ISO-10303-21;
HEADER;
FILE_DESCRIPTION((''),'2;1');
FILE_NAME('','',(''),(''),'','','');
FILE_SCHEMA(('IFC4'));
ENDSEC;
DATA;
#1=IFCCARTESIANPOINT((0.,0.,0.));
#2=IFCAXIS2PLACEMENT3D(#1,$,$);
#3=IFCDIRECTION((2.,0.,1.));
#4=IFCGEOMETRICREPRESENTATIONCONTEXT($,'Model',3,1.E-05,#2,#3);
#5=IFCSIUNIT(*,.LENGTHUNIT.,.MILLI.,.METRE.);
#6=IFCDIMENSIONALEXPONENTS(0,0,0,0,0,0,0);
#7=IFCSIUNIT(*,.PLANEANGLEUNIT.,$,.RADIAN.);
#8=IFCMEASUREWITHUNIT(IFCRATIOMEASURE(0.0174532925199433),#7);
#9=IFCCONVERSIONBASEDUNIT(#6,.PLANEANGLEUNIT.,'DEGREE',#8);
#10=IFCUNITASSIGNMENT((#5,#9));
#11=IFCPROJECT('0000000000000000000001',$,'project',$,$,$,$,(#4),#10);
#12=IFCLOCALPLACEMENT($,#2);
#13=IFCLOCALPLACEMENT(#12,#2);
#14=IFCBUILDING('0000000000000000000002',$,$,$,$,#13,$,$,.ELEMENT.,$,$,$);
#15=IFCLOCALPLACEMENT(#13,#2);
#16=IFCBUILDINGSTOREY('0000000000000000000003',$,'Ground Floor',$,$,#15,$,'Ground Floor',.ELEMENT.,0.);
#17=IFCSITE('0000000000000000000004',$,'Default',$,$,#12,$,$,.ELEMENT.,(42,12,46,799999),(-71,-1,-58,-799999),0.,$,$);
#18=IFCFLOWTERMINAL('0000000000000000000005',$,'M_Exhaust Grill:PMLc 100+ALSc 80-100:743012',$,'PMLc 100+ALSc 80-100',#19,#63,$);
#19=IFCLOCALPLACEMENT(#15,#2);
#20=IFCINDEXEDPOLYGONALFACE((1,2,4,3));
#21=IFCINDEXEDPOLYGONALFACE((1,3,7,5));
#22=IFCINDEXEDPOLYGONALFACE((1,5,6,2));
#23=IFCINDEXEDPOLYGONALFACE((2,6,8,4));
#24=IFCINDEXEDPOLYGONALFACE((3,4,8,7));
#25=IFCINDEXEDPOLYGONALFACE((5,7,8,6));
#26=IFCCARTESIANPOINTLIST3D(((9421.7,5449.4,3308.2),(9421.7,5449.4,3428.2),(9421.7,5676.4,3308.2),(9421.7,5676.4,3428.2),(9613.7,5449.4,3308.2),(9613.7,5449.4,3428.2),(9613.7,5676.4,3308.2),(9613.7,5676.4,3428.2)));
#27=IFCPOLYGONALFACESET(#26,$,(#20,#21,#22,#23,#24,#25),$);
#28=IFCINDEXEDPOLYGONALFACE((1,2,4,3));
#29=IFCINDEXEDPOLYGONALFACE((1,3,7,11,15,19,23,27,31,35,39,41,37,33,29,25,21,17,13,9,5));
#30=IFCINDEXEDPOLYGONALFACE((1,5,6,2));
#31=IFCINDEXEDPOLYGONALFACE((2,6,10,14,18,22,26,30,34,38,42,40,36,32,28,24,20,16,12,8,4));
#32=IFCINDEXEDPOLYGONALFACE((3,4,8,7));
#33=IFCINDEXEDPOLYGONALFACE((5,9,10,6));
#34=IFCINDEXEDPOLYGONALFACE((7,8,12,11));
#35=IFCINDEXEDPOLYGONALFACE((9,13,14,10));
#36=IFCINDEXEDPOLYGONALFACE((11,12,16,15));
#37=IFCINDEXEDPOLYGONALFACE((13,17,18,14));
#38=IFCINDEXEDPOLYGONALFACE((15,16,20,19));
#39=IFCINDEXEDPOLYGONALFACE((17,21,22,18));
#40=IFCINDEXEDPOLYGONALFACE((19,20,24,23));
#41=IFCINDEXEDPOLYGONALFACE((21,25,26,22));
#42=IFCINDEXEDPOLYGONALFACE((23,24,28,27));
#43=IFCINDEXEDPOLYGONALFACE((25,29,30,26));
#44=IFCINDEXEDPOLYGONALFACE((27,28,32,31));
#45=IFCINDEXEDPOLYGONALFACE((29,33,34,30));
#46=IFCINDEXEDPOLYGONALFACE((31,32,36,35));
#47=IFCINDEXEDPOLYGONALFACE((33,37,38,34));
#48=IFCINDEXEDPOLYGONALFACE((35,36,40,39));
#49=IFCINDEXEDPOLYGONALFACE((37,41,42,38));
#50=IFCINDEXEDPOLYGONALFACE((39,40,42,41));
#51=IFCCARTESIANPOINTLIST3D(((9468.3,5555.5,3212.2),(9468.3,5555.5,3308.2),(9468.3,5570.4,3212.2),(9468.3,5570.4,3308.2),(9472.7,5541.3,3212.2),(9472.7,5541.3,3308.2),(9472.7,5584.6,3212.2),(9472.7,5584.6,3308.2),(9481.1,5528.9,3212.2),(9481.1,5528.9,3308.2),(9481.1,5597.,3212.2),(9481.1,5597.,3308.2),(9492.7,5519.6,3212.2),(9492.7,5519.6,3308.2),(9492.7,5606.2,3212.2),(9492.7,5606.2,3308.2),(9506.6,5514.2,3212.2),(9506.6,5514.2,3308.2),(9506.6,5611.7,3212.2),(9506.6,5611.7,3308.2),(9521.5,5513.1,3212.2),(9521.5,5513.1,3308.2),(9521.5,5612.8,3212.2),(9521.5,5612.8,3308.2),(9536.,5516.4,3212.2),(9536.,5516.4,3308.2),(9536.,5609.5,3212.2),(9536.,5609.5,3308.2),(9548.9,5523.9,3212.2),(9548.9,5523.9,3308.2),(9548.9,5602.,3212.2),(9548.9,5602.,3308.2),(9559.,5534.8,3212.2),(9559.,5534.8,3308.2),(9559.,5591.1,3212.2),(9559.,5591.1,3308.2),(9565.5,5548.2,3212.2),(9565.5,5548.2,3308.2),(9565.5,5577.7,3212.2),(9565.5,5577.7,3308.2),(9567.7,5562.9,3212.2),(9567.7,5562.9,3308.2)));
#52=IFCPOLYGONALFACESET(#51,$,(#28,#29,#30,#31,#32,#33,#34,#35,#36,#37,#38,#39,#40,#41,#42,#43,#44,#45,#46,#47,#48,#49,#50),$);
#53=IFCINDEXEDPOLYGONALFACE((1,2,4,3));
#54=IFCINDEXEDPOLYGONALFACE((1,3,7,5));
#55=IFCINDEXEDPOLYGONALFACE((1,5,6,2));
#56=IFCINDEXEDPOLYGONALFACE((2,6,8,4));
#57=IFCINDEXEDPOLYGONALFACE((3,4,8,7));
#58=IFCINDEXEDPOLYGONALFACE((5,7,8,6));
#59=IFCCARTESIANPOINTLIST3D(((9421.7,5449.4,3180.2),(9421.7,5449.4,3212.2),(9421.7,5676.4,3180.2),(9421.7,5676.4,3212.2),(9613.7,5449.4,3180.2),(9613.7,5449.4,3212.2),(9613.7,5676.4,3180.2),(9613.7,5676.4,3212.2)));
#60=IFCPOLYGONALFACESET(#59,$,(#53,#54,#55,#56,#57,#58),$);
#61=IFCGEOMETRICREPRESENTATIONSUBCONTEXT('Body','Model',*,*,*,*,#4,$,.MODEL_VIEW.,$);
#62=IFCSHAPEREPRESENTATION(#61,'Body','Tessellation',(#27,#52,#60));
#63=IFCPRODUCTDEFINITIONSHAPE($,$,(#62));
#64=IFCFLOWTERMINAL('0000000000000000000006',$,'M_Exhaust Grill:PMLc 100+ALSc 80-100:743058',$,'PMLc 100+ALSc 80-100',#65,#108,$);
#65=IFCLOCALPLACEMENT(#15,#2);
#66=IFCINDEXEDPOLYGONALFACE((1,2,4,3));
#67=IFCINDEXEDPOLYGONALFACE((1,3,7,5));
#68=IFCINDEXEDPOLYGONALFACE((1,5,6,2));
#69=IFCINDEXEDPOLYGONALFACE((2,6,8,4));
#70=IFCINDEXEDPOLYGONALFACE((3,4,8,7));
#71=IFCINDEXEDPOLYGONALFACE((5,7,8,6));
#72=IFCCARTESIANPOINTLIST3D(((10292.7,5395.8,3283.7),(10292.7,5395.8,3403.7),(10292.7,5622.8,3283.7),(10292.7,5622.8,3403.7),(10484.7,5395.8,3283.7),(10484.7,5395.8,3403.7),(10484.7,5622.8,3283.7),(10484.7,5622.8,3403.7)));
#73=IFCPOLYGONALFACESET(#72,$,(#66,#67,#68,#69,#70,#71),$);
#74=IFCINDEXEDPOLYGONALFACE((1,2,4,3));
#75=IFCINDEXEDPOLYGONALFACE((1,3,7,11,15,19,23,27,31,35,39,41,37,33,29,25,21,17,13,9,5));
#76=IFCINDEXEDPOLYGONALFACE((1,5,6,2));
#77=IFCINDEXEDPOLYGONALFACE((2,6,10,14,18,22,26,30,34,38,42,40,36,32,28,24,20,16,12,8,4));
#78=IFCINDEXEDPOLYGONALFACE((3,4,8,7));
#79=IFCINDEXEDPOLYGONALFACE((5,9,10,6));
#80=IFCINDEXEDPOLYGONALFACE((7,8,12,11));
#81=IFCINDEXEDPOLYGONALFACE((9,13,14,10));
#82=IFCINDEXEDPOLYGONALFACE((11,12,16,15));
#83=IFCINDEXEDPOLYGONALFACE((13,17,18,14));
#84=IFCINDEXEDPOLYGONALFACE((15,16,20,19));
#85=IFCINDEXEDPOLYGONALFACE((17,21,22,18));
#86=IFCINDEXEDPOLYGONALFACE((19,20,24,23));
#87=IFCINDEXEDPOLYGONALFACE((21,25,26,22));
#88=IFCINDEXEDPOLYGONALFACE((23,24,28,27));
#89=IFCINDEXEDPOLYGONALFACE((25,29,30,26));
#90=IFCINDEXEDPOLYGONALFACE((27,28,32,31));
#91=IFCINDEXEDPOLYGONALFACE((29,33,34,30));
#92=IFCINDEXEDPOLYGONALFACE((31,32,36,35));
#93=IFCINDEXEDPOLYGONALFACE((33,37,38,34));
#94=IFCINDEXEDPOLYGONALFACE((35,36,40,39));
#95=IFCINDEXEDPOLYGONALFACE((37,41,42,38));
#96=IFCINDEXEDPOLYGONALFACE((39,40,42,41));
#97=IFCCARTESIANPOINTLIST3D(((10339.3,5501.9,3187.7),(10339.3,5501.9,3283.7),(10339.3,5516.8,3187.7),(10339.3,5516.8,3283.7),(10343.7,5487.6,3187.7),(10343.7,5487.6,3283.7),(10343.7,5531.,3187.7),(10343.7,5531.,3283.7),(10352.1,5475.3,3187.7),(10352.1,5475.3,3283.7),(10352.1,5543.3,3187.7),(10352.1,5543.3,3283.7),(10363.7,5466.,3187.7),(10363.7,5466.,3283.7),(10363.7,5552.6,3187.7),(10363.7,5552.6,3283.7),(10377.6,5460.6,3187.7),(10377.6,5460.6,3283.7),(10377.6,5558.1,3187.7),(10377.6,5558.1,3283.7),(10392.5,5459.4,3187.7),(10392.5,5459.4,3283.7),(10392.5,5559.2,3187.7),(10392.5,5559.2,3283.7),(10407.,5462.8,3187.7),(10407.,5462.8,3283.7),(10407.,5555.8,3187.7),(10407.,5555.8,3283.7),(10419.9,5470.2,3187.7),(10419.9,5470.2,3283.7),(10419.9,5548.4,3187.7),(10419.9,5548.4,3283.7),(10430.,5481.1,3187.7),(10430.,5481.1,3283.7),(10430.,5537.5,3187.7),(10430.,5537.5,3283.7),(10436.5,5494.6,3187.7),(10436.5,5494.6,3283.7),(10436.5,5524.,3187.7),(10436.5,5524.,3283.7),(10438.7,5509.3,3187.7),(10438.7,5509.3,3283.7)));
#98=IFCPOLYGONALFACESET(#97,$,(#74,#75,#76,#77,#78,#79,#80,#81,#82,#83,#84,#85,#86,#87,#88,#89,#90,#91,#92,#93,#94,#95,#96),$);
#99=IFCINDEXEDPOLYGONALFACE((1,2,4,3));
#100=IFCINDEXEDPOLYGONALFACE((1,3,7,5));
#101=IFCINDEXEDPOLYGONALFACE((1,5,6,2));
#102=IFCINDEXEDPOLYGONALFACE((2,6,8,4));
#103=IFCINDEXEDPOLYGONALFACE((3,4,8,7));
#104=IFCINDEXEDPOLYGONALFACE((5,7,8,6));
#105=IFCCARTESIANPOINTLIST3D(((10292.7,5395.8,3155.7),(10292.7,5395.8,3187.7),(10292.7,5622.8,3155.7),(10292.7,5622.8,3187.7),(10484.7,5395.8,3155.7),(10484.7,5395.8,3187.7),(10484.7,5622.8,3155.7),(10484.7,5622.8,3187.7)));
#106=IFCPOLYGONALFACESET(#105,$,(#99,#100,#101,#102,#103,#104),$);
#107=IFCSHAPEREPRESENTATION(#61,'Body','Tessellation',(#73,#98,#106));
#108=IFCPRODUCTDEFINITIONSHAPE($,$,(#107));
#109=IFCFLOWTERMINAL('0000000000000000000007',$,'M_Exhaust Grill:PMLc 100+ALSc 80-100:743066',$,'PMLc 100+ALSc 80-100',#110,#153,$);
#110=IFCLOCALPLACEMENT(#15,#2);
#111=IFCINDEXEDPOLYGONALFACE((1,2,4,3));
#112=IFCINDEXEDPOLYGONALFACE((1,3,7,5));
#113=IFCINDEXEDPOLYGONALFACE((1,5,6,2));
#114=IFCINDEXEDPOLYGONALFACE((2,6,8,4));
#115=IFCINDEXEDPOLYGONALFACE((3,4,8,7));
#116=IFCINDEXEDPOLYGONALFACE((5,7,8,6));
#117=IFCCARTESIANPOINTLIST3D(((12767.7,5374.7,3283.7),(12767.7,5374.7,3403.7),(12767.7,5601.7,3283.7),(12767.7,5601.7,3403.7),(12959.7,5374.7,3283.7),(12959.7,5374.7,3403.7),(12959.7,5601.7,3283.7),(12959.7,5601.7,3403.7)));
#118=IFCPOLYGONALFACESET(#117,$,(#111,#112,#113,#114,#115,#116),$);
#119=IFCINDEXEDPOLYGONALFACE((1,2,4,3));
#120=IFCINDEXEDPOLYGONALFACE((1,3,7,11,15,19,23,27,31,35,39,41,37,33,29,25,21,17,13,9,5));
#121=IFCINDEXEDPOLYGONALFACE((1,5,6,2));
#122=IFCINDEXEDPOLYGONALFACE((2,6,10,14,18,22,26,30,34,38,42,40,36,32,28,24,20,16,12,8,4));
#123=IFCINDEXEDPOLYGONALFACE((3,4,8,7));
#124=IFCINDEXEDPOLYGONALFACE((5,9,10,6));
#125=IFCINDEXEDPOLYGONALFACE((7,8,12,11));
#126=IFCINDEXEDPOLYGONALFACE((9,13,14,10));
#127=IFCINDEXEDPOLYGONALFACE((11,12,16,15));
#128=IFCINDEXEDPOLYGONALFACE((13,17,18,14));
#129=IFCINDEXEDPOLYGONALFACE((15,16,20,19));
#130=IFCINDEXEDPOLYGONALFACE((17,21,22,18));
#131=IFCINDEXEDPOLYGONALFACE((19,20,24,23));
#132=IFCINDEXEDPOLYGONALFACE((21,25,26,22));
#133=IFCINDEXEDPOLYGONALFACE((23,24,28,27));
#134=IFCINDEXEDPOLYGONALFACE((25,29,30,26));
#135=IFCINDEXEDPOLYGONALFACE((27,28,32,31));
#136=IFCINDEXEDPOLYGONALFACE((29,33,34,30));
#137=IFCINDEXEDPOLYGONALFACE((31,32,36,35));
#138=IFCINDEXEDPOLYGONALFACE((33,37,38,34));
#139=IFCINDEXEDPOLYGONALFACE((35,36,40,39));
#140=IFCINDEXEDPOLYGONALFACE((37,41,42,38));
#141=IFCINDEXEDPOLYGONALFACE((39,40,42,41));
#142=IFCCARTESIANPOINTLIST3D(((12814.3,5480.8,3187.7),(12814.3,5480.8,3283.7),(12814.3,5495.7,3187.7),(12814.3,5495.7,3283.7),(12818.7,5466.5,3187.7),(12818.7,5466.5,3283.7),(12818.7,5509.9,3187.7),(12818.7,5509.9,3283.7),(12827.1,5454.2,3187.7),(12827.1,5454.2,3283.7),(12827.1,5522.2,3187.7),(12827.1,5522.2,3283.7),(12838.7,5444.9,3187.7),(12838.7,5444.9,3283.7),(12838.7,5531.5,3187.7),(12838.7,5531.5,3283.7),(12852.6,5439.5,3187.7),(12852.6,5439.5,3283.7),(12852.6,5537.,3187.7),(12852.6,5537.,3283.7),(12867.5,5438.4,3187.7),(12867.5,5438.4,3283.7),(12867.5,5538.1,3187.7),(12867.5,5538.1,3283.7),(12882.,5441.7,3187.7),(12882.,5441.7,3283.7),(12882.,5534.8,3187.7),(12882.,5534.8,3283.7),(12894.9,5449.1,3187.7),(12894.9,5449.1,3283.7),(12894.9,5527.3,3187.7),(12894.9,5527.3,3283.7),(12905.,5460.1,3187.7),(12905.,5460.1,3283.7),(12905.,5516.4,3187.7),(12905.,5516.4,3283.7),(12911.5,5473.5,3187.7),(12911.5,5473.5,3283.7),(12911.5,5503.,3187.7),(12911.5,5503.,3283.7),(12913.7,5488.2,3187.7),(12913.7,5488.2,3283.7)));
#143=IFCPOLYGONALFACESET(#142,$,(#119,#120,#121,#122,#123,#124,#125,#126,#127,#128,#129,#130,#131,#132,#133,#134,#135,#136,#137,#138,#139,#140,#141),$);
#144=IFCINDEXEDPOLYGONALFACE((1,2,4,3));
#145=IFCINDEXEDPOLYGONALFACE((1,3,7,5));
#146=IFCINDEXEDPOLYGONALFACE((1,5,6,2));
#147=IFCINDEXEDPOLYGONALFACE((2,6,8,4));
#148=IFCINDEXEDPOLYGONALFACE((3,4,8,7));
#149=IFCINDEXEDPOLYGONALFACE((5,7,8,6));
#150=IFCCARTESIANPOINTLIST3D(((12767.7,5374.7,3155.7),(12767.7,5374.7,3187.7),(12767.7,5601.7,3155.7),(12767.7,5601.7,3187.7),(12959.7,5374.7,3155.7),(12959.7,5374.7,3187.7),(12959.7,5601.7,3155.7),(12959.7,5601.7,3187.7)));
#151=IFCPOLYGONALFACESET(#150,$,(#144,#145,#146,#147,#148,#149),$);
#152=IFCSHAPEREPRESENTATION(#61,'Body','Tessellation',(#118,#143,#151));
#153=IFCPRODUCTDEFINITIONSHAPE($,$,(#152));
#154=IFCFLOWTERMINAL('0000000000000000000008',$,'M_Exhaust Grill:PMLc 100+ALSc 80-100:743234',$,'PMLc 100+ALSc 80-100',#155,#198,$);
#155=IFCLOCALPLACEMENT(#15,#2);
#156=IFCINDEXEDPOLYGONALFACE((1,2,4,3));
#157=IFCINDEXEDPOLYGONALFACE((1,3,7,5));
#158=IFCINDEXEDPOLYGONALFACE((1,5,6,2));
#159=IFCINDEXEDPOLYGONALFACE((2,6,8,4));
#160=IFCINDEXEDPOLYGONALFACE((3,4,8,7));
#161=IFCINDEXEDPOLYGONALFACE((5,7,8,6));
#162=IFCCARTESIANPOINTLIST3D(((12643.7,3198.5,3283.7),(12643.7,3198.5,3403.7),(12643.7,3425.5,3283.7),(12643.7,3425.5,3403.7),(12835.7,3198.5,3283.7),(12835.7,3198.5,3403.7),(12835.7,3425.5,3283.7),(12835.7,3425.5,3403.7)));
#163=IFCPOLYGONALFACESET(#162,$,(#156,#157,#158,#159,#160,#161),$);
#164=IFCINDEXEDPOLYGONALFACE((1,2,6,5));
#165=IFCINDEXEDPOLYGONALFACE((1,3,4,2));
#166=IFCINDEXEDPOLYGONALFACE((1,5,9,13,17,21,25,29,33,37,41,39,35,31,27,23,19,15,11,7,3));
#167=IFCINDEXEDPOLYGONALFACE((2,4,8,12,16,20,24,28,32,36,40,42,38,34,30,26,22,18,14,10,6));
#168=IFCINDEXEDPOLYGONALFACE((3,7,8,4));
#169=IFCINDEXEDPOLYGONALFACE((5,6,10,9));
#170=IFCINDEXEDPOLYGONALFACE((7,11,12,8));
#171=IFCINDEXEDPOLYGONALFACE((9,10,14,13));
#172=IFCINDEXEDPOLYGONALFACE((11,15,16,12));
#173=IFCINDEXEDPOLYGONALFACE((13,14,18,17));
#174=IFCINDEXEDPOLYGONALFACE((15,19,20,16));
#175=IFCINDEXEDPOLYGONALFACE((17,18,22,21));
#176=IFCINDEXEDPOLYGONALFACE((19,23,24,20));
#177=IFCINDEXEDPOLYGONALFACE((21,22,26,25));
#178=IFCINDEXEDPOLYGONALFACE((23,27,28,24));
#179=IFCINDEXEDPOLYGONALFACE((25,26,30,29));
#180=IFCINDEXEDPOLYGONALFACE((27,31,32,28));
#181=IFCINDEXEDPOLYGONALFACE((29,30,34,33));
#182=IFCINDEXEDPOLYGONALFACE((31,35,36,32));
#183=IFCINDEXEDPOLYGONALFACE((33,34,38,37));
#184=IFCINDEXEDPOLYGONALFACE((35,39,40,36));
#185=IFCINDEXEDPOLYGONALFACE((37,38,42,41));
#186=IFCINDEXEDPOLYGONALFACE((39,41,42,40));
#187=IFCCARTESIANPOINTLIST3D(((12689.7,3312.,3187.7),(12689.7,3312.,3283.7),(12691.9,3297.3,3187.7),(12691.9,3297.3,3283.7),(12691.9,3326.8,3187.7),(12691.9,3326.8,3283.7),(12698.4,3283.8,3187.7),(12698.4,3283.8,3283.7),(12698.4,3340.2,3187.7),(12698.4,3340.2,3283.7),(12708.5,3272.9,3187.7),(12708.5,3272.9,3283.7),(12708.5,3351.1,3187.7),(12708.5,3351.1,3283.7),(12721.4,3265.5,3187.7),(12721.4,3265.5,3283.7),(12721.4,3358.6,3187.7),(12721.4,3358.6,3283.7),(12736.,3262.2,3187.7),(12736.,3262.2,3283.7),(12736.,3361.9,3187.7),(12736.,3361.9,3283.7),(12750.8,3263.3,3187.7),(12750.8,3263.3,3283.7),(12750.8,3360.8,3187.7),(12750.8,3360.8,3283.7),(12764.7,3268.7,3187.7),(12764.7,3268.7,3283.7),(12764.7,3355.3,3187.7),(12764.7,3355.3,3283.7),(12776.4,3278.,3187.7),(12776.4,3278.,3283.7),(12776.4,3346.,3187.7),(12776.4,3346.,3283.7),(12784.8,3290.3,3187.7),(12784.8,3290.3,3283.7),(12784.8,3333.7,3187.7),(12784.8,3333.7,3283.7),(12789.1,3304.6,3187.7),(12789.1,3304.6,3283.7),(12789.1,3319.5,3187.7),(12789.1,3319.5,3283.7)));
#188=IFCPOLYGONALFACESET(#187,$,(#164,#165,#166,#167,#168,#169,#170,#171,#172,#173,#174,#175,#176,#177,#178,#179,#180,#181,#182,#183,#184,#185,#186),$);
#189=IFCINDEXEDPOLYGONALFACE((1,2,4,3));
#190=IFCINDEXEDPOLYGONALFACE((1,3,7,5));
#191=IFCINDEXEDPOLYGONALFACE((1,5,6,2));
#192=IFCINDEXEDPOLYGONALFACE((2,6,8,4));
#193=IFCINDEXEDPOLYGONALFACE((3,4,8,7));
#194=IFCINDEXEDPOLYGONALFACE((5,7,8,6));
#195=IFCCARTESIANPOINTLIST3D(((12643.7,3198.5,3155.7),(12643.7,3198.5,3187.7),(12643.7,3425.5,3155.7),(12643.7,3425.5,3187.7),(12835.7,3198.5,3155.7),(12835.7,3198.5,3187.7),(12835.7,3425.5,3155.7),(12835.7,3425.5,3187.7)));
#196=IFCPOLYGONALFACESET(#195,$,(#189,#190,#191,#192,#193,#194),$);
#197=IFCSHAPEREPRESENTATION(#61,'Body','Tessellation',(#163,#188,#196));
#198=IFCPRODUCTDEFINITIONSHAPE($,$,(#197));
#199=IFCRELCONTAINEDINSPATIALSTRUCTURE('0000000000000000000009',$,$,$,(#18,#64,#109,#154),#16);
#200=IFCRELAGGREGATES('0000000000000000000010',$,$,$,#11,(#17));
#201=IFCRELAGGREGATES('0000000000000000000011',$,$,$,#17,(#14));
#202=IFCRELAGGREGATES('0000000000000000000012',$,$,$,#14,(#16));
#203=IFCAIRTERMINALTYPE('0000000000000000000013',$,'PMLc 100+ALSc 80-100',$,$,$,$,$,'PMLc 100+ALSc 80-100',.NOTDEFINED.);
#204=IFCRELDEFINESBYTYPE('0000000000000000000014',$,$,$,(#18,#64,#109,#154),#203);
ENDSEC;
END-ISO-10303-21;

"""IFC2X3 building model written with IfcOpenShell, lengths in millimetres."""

from ifc_helpers import new_model, entity, si_unit, converted_unit, direction, frame, frame_2d, origin, origin_2d_with_axis, place, context, subcontext, project, spatial, rectangle, circle, extrude, source, transform, mapped, type_object, type_shapes, element, save


model = new_model("IFC2X3")

# Units and contexts
model_context = context("Model", 3, precision=1e-05, world=origin(), true_north=direction((2.0, 0.0, 1.0)))
body_context = subcontext(model_context, "Body", "Model", "MODEL_VIEW")
ifc_project = project(units=[si_unit("LENGTHUNIT", "METRE", prefix="MILLI"), converted_unit("PLANEANGLEUNIT", "DEGREE", entity("IfcRatioMeasure", 0.0174532925199433), si_unit("PLANEANGLEUNIT", "RADIAN"), dimensions=[0, 0, 0, 0, 0, 0, 0])], contexts=[model_context])

# Site, building, storey
site_placement = place(None, origin())
site = spatial("IfcSite", under=ifc_project, at=site_placement, Name="Default", CompositionType="ELEMENT", RefLatitude=(42, 12, 46, 799999), RefLongitude=(-71, -1, -58, -799999), RefElevation=0.0)
building_placement = place(site_placement, origin())
building = spatial("IfcBuilding", under=site, at=building_placement, CompositionType="ELEMENT")
storey_placement = place(building_placement, origin())
storey = spatial("IfcBuildingStorey", under=building, at=storey_placement, Name="Ground Floor", LongName="Ground Floor", CompositionType="ELEMENT", Elevation=0.0)

# Flow terminals
air_terminal_type_1 = type_object("IfcAirTerminalType", Name="PMLc 100+ALSc 80-100", ElementType="PMLc 100+ALSc 80-100", PredefinedType="NOTDEFINED")
shared_shape_1 = source(origin(), body_context, "Body", "SweptSolid", [
    extrude(rectangle(XDim=227.0, YDim=192.0, at=origin_2d_with_axis()), frame((0.0, 3.8, 128.0), z_axis=(0.0, 0.0, 1.0), x_axis=(0.0, 1.0, 0.0)), (0.0, 0.0, 1.0), 120.0),
    extrude(circle(Radius=50.0, at=frame_2d((0.0, 0.0), x_axis=(1.0, 0.0))), frame((0.0, 3.8, 32.0)), (0.0, 0.0, 1.0), 96.0),
    extrude(rectangle(XDim=227.0, YDim=192.0, at=origin_2d_with_axis()), frame((0.0, 3.8, 0.0), z_axis=(0.0, 0.0, 1.0), x_axis=(0.0, 1.0, 0.0)), (0.0, 0.0, 1.0), 32.0),
])
type_shapes(air_terminal_type_1, [shared_shape_1])
for number, where, name in (
    (1, (9517.7, 5559.2, 3180.2), "M_Exhaust Grill:PMLc 100+ALSc 80-100:743012"),
    (2, (10388.7, 5505.5, 3155.7), "M_Exhaust Grill:PMLc 100+ALSc 80-100:743058"),
    (3, (12863.7, 5484.5, 3155.7), "M_Exhaust Grill:PMLc 100+ALSc 80-100:743066"),
):
    element("IfcFlowTerminal", number, at=place(storey_placement, frame(where)), inside=storey, type_object=air_terminal_type_1, Name=name, ObjectType="PMLc 100+ALSc 80-100", context=body_context, shape_type="MappedRepresentation", body=[
        mapped(shared_shape_1, transform((0.0, 0.0, 0.0), scale=1.0)),
    ])
for number, where, z_axis, x_axis, name in (
    (4, (12739.7, 3315.8, 3155.7), (0.0, 0.0, 1.0), (-1.0, 0.0, 0.0), "M_Exhaust Grill:PMLc 100+ALSc 80-100:743234"),
):
    element("IfcFlowTerminal", number, at=place(storey_placement, frame(where, z_axis=z_axis, x_axis=x_axis)), inside=storey, type_object=air_terminal_type_1, Name=name, ObjectType="PMLc 100+ALSc 80-100", context=body_context, shape_type="MappedRepresentation", body=[
        mapped(shared_shape_1, transform((0.0, 0.0, 0.0), scale=1.0)),
    ])

save(model, "model.ifc")
